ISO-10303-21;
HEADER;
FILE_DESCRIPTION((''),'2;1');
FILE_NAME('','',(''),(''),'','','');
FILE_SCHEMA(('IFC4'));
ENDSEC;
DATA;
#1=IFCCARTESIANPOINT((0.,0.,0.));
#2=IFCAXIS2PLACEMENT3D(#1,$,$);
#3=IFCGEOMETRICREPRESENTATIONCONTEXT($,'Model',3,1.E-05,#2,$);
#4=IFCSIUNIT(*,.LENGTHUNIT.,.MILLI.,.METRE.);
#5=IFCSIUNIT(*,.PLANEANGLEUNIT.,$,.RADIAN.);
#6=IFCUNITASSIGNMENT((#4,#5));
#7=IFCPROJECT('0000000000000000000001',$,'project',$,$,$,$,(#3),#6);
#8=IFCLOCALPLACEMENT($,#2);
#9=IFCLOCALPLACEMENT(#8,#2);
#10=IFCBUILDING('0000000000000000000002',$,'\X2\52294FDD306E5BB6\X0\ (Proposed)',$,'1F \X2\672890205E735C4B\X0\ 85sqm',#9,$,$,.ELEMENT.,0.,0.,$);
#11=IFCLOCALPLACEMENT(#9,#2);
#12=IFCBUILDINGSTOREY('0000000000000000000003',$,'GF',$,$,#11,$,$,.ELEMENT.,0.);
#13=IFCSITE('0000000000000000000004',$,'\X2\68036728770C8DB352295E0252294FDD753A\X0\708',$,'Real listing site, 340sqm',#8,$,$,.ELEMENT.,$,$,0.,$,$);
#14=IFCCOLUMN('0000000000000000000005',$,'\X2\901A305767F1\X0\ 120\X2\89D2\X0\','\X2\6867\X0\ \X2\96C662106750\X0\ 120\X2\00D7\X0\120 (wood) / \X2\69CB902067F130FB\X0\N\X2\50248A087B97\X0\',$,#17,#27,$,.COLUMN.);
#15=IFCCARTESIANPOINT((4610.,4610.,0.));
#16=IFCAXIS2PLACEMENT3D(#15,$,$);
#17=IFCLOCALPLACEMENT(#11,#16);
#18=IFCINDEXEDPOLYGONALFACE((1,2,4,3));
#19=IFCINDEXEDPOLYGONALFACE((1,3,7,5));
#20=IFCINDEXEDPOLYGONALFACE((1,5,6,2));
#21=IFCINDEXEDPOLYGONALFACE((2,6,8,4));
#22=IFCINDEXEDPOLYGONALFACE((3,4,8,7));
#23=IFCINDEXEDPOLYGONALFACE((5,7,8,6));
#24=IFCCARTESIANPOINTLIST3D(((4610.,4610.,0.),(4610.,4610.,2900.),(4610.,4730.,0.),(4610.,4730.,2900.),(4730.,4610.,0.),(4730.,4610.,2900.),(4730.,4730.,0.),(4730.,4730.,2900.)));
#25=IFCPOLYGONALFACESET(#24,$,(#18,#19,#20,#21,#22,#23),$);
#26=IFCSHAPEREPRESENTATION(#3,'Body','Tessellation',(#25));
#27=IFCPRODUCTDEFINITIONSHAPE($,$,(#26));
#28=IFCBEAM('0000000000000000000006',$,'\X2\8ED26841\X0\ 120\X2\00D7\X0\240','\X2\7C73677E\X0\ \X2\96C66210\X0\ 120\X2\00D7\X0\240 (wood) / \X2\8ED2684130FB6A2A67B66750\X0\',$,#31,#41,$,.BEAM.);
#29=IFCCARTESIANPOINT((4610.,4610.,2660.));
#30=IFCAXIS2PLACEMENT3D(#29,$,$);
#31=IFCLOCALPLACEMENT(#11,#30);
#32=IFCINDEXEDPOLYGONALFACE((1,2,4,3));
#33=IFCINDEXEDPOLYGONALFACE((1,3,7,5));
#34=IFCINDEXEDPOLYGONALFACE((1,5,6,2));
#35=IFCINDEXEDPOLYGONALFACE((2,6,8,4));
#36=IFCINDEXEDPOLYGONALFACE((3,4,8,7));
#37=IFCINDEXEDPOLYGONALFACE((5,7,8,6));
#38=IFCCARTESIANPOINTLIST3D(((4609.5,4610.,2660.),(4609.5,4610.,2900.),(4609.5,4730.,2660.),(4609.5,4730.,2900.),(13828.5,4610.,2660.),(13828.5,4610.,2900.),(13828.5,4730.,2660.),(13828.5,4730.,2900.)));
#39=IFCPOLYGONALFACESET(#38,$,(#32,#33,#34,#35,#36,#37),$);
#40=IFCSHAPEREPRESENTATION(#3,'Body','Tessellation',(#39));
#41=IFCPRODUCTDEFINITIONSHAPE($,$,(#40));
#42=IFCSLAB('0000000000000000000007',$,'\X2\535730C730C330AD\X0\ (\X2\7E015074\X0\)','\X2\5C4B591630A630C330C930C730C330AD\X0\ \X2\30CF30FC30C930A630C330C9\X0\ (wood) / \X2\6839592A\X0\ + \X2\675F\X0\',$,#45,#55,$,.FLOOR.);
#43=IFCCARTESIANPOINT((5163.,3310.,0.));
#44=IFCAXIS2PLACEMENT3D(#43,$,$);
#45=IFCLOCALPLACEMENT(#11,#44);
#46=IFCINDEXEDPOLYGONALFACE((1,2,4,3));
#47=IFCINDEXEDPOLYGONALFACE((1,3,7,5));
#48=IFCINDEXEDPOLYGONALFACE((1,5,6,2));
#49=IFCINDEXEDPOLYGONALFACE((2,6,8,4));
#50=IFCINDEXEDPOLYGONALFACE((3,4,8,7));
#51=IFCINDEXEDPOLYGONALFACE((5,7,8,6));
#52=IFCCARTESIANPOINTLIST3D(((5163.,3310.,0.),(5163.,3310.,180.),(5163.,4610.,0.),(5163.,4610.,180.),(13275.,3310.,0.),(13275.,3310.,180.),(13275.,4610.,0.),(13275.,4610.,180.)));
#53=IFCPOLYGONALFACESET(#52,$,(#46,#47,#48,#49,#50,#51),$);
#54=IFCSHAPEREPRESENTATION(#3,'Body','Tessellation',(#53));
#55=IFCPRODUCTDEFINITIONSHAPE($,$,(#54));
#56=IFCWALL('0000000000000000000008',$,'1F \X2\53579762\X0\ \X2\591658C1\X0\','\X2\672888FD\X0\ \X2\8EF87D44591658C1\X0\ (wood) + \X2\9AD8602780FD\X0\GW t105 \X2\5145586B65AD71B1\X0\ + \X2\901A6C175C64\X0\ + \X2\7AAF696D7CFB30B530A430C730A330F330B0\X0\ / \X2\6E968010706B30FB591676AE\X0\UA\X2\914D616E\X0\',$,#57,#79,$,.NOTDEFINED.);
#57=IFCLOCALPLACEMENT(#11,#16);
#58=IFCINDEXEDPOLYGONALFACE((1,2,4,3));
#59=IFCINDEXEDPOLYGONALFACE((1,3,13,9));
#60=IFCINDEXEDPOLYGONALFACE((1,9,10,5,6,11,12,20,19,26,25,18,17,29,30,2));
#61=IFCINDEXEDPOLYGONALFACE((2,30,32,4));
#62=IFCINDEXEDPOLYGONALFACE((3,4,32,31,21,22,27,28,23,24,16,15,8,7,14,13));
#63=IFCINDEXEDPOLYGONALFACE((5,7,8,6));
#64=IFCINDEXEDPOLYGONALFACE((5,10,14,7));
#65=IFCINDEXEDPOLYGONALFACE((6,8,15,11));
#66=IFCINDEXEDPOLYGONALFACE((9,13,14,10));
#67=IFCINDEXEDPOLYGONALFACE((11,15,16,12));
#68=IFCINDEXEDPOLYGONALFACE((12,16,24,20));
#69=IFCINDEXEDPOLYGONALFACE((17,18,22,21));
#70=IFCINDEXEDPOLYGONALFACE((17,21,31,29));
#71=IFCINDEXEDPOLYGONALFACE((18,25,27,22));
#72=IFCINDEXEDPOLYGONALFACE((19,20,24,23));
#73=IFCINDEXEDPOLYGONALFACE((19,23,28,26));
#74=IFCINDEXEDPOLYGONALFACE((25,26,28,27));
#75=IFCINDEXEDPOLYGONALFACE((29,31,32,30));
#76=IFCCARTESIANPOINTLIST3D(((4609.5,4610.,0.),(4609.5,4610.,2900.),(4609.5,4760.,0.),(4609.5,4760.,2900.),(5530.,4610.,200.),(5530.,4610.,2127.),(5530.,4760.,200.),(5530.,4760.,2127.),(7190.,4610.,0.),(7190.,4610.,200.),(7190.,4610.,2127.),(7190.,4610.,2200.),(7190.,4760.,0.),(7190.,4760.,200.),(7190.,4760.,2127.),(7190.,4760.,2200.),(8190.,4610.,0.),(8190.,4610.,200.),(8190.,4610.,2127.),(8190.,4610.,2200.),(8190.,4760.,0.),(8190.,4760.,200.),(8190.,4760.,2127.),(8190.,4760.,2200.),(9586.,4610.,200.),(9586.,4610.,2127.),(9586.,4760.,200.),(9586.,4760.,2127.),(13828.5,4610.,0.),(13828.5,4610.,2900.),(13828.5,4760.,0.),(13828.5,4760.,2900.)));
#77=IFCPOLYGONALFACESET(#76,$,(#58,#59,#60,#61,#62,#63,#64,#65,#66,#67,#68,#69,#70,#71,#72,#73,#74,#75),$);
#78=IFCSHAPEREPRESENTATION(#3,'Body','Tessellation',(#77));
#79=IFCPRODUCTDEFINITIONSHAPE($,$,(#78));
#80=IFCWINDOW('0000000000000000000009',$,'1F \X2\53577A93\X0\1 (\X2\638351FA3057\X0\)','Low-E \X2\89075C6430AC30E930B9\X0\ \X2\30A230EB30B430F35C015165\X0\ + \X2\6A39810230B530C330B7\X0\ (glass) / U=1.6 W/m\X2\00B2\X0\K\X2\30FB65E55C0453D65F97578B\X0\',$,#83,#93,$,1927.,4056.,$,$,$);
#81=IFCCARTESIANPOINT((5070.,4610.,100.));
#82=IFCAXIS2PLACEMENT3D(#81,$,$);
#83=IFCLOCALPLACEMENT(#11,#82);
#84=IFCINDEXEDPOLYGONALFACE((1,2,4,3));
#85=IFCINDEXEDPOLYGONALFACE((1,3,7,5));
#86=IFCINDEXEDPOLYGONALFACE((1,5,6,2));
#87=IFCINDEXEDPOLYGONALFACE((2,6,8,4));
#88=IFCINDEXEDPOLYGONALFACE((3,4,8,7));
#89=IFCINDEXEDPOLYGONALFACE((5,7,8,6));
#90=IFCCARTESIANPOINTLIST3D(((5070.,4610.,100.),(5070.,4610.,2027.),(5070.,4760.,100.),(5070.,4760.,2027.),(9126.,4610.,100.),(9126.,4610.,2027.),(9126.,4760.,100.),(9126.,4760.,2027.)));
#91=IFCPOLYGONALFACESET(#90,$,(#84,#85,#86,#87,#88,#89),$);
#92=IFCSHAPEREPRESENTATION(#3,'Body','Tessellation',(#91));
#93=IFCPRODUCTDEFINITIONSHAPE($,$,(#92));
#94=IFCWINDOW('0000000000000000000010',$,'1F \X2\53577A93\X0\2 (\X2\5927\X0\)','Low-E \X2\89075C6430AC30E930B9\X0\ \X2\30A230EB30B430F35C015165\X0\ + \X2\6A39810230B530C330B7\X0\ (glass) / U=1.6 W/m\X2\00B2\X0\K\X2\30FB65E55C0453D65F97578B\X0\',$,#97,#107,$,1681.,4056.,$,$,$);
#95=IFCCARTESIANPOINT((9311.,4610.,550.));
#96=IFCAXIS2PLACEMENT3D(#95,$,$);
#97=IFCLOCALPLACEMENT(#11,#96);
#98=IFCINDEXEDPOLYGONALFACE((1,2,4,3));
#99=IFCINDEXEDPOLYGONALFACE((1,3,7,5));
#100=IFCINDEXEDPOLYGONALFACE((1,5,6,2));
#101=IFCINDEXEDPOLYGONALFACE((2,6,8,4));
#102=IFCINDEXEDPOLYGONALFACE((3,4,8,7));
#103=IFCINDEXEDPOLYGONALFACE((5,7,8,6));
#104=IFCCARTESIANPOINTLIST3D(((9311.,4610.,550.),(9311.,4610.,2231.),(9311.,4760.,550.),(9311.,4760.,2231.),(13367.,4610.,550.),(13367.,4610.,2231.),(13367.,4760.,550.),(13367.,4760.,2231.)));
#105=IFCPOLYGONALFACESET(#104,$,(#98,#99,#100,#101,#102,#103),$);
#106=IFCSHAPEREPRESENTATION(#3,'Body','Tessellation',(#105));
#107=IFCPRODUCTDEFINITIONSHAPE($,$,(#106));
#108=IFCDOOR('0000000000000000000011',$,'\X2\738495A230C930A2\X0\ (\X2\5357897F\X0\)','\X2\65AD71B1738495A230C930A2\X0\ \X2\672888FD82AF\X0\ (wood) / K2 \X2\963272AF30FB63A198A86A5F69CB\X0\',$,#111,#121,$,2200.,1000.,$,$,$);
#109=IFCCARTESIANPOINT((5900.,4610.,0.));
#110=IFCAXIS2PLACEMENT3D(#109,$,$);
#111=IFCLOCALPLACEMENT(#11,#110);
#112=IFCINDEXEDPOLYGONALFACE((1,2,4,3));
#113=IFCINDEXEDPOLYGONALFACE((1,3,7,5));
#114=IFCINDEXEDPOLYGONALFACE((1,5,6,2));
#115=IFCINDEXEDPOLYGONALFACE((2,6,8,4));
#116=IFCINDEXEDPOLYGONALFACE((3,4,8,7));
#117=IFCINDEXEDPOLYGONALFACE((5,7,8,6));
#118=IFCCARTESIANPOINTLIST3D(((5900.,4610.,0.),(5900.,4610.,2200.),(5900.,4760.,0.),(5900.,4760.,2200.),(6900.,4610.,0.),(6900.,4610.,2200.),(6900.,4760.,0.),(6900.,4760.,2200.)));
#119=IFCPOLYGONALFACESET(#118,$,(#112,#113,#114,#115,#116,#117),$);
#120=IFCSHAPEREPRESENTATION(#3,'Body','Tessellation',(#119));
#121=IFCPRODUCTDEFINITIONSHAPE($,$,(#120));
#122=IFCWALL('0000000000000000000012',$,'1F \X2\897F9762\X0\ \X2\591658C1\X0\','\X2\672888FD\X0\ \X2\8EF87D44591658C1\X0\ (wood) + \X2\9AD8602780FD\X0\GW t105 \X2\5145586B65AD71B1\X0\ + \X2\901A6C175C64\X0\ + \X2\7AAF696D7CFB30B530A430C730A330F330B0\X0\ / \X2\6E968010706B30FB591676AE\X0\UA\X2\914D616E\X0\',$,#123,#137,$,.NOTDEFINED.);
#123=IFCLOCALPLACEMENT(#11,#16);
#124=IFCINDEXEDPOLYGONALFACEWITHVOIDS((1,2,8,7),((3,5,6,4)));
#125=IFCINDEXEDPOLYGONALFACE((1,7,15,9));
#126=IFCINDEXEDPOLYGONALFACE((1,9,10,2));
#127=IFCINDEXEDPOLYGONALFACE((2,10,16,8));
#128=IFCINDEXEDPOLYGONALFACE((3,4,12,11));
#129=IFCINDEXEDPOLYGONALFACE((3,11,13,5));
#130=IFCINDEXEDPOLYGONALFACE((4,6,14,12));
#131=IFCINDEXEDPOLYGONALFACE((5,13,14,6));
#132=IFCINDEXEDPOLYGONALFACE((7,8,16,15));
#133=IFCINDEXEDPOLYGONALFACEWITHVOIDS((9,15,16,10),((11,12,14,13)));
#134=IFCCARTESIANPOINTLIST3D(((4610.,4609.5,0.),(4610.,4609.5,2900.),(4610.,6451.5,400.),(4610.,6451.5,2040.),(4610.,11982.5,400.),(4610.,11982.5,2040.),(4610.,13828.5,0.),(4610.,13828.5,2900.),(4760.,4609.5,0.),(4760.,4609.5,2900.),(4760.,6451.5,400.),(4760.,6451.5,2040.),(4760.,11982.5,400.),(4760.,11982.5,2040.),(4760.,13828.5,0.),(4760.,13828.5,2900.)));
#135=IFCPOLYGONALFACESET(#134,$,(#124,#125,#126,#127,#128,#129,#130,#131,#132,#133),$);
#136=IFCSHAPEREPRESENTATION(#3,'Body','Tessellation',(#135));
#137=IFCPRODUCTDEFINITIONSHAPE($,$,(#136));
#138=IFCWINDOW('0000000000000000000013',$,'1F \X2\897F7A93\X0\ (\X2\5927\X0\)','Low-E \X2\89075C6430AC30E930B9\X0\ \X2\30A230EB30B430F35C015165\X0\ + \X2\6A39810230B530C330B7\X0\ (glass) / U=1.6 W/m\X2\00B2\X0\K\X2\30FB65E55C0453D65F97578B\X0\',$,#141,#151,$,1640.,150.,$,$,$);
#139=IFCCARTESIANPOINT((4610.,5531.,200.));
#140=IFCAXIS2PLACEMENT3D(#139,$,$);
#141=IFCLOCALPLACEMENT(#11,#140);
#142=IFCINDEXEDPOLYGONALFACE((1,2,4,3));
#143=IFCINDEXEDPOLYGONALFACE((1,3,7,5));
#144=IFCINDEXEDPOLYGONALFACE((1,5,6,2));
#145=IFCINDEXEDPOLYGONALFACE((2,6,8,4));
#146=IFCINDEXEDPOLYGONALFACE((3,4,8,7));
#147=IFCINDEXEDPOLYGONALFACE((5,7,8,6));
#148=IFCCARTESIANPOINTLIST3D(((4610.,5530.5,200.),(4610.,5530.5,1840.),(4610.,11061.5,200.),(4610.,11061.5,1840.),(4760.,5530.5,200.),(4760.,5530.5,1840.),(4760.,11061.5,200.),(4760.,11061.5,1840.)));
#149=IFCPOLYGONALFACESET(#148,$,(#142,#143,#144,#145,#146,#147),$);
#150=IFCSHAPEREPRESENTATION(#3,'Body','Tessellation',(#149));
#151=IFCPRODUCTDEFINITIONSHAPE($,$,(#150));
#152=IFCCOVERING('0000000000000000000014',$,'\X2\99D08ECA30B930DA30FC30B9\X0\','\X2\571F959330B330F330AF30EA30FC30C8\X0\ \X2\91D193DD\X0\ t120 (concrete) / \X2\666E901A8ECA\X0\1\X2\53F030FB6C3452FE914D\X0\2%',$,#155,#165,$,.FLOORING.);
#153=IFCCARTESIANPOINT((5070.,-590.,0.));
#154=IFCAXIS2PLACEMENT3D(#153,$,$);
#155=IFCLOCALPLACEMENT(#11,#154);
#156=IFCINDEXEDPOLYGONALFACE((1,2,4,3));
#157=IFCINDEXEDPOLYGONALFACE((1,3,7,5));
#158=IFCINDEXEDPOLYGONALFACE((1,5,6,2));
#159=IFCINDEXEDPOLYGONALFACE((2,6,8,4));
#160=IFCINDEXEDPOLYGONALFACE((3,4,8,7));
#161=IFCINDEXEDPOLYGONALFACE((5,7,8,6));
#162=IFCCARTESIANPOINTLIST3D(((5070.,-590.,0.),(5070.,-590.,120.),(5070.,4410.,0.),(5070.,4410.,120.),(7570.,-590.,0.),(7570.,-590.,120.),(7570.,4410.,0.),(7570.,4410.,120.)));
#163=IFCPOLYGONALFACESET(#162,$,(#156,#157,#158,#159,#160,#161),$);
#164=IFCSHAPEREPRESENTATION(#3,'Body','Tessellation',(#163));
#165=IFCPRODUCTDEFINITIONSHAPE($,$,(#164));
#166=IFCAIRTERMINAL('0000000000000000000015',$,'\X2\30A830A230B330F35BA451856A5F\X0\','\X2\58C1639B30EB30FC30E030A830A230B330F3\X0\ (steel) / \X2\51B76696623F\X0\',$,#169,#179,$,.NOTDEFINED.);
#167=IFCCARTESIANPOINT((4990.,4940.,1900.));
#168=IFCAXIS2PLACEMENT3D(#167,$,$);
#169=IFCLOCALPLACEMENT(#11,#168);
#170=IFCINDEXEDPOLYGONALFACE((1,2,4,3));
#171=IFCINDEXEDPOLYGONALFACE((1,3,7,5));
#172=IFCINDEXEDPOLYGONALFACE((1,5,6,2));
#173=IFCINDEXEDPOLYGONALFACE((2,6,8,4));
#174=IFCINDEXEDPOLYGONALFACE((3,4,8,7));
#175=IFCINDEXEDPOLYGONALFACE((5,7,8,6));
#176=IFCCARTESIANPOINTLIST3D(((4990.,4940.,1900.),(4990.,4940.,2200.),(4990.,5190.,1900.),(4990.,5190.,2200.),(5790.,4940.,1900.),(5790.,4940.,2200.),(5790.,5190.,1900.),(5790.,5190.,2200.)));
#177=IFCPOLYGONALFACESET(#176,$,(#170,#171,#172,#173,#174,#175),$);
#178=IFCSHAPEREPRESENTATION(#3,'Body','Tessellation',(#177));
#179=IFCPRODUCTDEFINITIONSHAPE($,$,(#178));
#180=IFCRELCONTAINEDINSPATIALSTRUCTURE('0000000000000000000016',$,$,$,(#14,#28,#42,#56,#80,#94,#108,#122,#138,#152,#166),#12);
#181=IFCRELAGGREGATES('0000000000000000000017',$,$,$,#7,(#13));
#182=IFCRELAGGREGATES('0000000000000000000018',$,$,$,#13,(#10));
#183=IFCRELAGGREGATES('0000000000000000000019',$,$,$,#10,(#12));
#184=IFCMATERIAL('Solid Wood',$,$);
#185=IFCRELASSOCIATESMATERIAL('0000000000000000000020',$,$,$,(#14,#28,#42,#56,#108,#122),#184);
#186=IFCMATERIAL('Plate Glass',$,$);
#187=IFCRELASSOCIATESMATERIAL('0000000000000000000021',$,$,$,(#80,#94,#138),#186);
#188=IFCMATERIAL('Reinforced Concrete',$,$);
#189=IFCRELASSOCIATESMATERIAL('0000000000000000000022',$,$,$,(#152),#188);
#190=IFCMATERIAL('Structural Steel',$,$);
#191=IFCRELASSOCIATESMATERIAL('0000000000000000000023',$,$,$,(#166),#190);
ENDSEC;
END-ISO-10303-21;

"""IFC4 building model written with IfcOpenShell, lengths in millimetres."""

from ifc_helpers import new_model, si_unit, frame, frame_2d, origin, place, context, project, spatial, rectangle, extrude, material, element, fill, save


model = new_model("IFC4")

# Units and contexts
model_context = context("Model", 3, precision=1e-05, world=origin())
ifc_project = project(units=[si_unit("LENGTHUNIT", "METRE", prefix="MILLI"), si_unit("PLANEANGLEUNIT", "RADIAN")], contexts=[model_context])

# Site, building, storey
site_placement = place(None, origin())
site = spatial("IfcSite", under=ifc_project, at=site_placement, Name="栃木県足利市利保町708", ObjectType="Real listing site, 340sqm", CompositionType="ELEMENT", RefElevation=0.0)
building_placement = place(site_placement, origin())
building = spatial("IfcBuilding", under=site, at=building_placement, Name="利保の家 (Proposed)", ObjectType="1F 木造平屋 85sqm", CompositionType="ELEMENT", ElevationOfRefHeight=0.0, ElevationOfTerrain=0.0)
storey_placement = place(building_placement, origin())
storey = spatial("IfcBuildingStorey", under=building, at=storey_placement, Name="GF", CompositionType="ELEMENT", Elevation=0.0)

# Column
ifc_material_1 = material(Name="Solid Wood")
column_1_placement = place(storey_placement, frame((4610.0, 4610.0, 0.0)))
element("IfcColumn", 1, at=column_1_placement, inside=storey, material=ifc_material_1, Name="通し柱 120角", Description="桧 集成材 120×120 (wood) / 構造柱・N値計算", PredefinedType="COLUMN", context=model_context, shape_type="SweptSolid", body=[
    extrude(rectangle(XDim=120.0, YDim=120.0, at=frame_2d((60.0, 60.0))), frame((4610.0, 4610.0, 0.0)), (0.0, 0.0, 1.0), 2900.0),
])

# Beam
beam_1_placement = place(storey_placement, frame((4610.0, 4610.0, 2660.0)))
element("IfcBeam", 2, at=beam_1_placement, inside=storey, material=ifc_material_1, Name="軒桁 120×240", Description="米松 集成 120×240 (wood) / 軒桁・横架材", PredefinedType="BEAM", context=model_context, shape_type="SweptSolid", body=[
    extrude(rectangle(XDim=9219.0, YDim=120.0, at=frame_2d((4609.0, 60.0))), frame((4610.0, 4610.0, 2660.0)), (0.0, 0.0, 1.0), 240.0),
])

# Slab
ifc_material_2 = material(Name="Reinforced Concrete")
slab_1_placement = place(storey_placement, frame((5163.0, 3310.0, 0.0)))
element("IfcSlab", 3, at=slab_1_placement, inside=storey, material=ifc_material_1, Name="南デッキ (縁側)", Description="屋外ウッドデッキ ハードウッド (wood) / 根太 + 束", PredefinedType="FLOOR", context=model_context, shape_type="SweptSolid", body=[
    extrude(rectangle(XDim=8112.0, YDim=1300.0, at=frame_2d((4056.0, 650.0))), frame((5163.0, 3310.0, 0.0)), (0.0, 0.0, 1.0), 180.0),
])

# Wall, openings, windows, door
wall_1_placement = place(storey_placement, frame((4610.0, 4610.0, 0.0)))
wall_1 = element("IfcWall", 4, at=wall_1_placement, inside=storey, material=ifc_material_1, Name="1F 南面 外壁", Description="木製 軸組外壁 (wood) + 高性能GW t105 充填断熱 + 通気層 + 窯業系サイディング / 準耐火・外皮UA配慮", PredefinedType="NOTDEFINED", context=model_context, shape_type="SweptSolid", body=[
    extrude(rectangle(XDim=9219.0, YDim=150.0, at=frame_2d((4609.0, 75.0))), frame((4610.0, 4610.0, 0.0)), (0.0, 0.0, 1.0), 2900.0),
])
opening_1_placement = place(storey_placement, frame((5070.0, 4610.0, 100.0)))
opening_1 = element("IfcOpeningElement", 5, at=opening_1_placement, cuts=wall_1, PredefinedType="NOTDEFINED", context=model_context, shape_type="SweptSolid", body=[
    extrude(rectangle(XDim=4056.0, YDim=150.0, at=frame_2d((2028.0, 75.0))), frame((5070.0, 4610.0, 100.0)), (0.0, 0.0, 1.0), 1927.0),
])
opening_2_placement = place(storey_placement, frame((9311.0, 4610.0, 550.0)))
opening_2 = element("IfcOpeningElement", 6, at=opening_2_placement, cuts=wall_1, PredefinedType="NOTDEFINED", context=model_context, shape_type="SweptSolid", body=[
    extrude(rectangle(XDim=4056.0, YDim=150.0, at=frame_2d((2028.0, 75.0))), frame((9311.0, 4610.0, 550.0)), (0.0, 0.0, 1.0), 1681.0),
])
opening_3_placement = place(storey_placement, frame((5900.0, 4610.0, 0.0)))
opening_3 = element("IfcOpeningElement", 7, at=opening_3_placement, cuts=wall_1, PredefinedType="NOTDEFINED", context=model_context, shape_type="SweptSolid", body=[
    extrude(rectangle(XDim=1000.0, YDim=150.0, at=frame_2d((500.0, 75.0))), frame((5900.0, 4610.0, 0.0)), (0.0, 0.0, 1.0), 2200.0),
])
ifc_material_3 = material(Name="Plate Glass")
window_1_placement = place(storey_placement, frame((5070.0, 4610.0, 100.0)))
window_1 = element("IfcWindow", 8, at=window_1_placement, inside=storey, material=ifc_material_3, Name="1F 南窓1 (掃出し)", Description="Low-E 複層ガラス アルゴン封入 + 樹脂サッシ (glass) / U=1.6 W/m²K・日射取得型", OverallHeight=1927.0, OverallWidth=4056.0, context=model_context, shape_type="SweptSolid", body=[
    extrude(rectangle(XDim=4056.0, YDim=150.0, at=frame_2d((2028.0, 75.0))), frame((5070.0, 4610.0, 100.0)), (0.0, 0.0, 1.0), 1927.0),
])
fill(opening_1, window_1)
window_2_placement = place(storey_placement, frame((9311.0, 4610.0, 550.0)))
window_2 = element("IfcWindow", 9, at=window_2_placement, inside=storey, material=ifc_material_3, Name="1F 南窓2 (大)", Description="Low-E 複層ガラス アルゴン封入 + 樹脂サッシ (glass) / U=1.6 W/m²K・日射取得型", OverallHeight=1681.0, OverallWidth=4056.0, context=model_context, shape_type="SweptSolid", body=[
    extrude(rectangle(XDim=4056.0, YDim=150.0, at=frame_2d((2028.0, 75.0))), frame((9311.0, 4610.0, 550.0)), (0.0, 0.0, 1.0), 1681.0),
])
fill(opening_2, window_2)
door_placement = place(storey_placement, frame((5900.0, 4610.0, 0.0)))
door = element("IfcDoor", 10, at=door_placement, inside=storey, material=ifc_material_1, Name="玄関ドア (南西)", Description="断熱玄関ドア 木製芯 (wood) / K2 防犯・採風機構", OverallHeight=2200.0, OverallWidth=1000.0, context=model_context, shape_type="SweptSolid", body=[
    extrude(rectangle(XDim=1000.0, YDim=150.0, at=frame_2d((500.0, 75.0))), frame((5900.0, 4610.0, 0.0)), (0.0, 0.0, 1.0), 2200.0),
])
fill(opening_3, door)

# Wall, opening, window
wall_2_placement = place(storey_placement, frame((4610.0, 4610.0, 0.0)))
wall_2 = element("IfcWall", 11, at=wall_2_placement, inside=storey, material=ifc_material_1, Name="1F 西面 外壁", Description="木製 軸組外壁 (wood) + 高性能GW t105 充填断熱 + 通気層 + 窯業系サイディング / 準耐火・外皮UA配慮", PredefinedType="NOTDEFINED", context=model_context, shape_type="SweptSolid", body=[
    extrude(rectangle(XDim=150.0, YDim=9219.0, at=frame_2d((75.0, 4609.0))), frame((4610.0, 4610.0, 0.0)), (0.0, 0.0, 1.0), 2900.0),
])
opening_4_placement = place(storey_placement, frame((4610.0, 5531.0, 200.0)))
opening_4 = element("IfcOpeningElement", 12, at=opening_4_placement, cuts=wall_2, PredefinedType="NOTDEFINED", context=model_context, shape_type="SweptSolid", body=[
    extrude(rectangle(XDim=150.0, YDim=5531.0, at=frame_2d((75.0, 2765.0))), frame((4610.0, 5531.0, 200.0)), (0.0, 0.0, 1.0), 1640.0),
])
window_3_placement = place(storey_placement, frame((4610.0, 5531.0, 200.0)))
window_3 = element("IfcWindow", 13, at=window_3_placement, inside=storey, material=ifc_material_3, Name="1F 西窓 (大)", Description="Low-E 複層ガラス アルゴン封入 + 樹脂サッシ (glass) / U=1.6 W/m²K・日射取得型", OverallHeight=1640.0, OverallWidth=150.0, context=model_context, shape_type="SweptSolid", body=[
    extrude(rectangle(XDim=150.0, YDim=5531.0, at=frame_2d((75.0, 2765.0))), frame((4610.0, 5531.0, 200.0)), (0.0, 0.0, 1.0), 1640.0),
])
fill(opening_4, window_3)

# Shared definitions
ifc_material_4 = material(Name="Structural Steel")

# Covering
covering_1_placement = place(storey_placement, frame((5070.0, -590.0, 0.0)))
element("IfcCovering", 14, at=covering_1_placement, inside=storey, material=ifc_material_2, Name="駐車スペース", Description="土間コンクリート 金鏝 t120 (concrete) / 普通車1台・水勾配2%", PredefinedType="FLOORING", context=model_context, shape_type="SweptSolid", body=[
    extrude(rectangle(XDim=2500.0, YDim=5000.0, at=frame_2d((1250.0, 2500.0))), frame((5070.0, -590.0, 0.0)), (0.0, 0.0, 1.0), 120.0),
])

# Air terminal
air_terminal_placement = place(storey_placement, frame((4990.0, 4940.0, 1900.0)))
element("IfcAirTerminal", 15, at=air_terminal_placement, inside=storey, material=ifc_material_4, Name="エアコン室内機", Description="壁掛ルームエアコン (steel) / 冷暖房", PredefinedType="NOTDEFINED", context=model_context, shape_type="SweptSolid", body=[
    extrude(rectangle(XDim=800.0, YDim=250.0, at=frame_2d((400.0, 125.0))), frame((4990.0, 4940.0, 1900.0)), (0.0, 0.0, 1.0), 300.0),
])

save(model, "model.ifc")
